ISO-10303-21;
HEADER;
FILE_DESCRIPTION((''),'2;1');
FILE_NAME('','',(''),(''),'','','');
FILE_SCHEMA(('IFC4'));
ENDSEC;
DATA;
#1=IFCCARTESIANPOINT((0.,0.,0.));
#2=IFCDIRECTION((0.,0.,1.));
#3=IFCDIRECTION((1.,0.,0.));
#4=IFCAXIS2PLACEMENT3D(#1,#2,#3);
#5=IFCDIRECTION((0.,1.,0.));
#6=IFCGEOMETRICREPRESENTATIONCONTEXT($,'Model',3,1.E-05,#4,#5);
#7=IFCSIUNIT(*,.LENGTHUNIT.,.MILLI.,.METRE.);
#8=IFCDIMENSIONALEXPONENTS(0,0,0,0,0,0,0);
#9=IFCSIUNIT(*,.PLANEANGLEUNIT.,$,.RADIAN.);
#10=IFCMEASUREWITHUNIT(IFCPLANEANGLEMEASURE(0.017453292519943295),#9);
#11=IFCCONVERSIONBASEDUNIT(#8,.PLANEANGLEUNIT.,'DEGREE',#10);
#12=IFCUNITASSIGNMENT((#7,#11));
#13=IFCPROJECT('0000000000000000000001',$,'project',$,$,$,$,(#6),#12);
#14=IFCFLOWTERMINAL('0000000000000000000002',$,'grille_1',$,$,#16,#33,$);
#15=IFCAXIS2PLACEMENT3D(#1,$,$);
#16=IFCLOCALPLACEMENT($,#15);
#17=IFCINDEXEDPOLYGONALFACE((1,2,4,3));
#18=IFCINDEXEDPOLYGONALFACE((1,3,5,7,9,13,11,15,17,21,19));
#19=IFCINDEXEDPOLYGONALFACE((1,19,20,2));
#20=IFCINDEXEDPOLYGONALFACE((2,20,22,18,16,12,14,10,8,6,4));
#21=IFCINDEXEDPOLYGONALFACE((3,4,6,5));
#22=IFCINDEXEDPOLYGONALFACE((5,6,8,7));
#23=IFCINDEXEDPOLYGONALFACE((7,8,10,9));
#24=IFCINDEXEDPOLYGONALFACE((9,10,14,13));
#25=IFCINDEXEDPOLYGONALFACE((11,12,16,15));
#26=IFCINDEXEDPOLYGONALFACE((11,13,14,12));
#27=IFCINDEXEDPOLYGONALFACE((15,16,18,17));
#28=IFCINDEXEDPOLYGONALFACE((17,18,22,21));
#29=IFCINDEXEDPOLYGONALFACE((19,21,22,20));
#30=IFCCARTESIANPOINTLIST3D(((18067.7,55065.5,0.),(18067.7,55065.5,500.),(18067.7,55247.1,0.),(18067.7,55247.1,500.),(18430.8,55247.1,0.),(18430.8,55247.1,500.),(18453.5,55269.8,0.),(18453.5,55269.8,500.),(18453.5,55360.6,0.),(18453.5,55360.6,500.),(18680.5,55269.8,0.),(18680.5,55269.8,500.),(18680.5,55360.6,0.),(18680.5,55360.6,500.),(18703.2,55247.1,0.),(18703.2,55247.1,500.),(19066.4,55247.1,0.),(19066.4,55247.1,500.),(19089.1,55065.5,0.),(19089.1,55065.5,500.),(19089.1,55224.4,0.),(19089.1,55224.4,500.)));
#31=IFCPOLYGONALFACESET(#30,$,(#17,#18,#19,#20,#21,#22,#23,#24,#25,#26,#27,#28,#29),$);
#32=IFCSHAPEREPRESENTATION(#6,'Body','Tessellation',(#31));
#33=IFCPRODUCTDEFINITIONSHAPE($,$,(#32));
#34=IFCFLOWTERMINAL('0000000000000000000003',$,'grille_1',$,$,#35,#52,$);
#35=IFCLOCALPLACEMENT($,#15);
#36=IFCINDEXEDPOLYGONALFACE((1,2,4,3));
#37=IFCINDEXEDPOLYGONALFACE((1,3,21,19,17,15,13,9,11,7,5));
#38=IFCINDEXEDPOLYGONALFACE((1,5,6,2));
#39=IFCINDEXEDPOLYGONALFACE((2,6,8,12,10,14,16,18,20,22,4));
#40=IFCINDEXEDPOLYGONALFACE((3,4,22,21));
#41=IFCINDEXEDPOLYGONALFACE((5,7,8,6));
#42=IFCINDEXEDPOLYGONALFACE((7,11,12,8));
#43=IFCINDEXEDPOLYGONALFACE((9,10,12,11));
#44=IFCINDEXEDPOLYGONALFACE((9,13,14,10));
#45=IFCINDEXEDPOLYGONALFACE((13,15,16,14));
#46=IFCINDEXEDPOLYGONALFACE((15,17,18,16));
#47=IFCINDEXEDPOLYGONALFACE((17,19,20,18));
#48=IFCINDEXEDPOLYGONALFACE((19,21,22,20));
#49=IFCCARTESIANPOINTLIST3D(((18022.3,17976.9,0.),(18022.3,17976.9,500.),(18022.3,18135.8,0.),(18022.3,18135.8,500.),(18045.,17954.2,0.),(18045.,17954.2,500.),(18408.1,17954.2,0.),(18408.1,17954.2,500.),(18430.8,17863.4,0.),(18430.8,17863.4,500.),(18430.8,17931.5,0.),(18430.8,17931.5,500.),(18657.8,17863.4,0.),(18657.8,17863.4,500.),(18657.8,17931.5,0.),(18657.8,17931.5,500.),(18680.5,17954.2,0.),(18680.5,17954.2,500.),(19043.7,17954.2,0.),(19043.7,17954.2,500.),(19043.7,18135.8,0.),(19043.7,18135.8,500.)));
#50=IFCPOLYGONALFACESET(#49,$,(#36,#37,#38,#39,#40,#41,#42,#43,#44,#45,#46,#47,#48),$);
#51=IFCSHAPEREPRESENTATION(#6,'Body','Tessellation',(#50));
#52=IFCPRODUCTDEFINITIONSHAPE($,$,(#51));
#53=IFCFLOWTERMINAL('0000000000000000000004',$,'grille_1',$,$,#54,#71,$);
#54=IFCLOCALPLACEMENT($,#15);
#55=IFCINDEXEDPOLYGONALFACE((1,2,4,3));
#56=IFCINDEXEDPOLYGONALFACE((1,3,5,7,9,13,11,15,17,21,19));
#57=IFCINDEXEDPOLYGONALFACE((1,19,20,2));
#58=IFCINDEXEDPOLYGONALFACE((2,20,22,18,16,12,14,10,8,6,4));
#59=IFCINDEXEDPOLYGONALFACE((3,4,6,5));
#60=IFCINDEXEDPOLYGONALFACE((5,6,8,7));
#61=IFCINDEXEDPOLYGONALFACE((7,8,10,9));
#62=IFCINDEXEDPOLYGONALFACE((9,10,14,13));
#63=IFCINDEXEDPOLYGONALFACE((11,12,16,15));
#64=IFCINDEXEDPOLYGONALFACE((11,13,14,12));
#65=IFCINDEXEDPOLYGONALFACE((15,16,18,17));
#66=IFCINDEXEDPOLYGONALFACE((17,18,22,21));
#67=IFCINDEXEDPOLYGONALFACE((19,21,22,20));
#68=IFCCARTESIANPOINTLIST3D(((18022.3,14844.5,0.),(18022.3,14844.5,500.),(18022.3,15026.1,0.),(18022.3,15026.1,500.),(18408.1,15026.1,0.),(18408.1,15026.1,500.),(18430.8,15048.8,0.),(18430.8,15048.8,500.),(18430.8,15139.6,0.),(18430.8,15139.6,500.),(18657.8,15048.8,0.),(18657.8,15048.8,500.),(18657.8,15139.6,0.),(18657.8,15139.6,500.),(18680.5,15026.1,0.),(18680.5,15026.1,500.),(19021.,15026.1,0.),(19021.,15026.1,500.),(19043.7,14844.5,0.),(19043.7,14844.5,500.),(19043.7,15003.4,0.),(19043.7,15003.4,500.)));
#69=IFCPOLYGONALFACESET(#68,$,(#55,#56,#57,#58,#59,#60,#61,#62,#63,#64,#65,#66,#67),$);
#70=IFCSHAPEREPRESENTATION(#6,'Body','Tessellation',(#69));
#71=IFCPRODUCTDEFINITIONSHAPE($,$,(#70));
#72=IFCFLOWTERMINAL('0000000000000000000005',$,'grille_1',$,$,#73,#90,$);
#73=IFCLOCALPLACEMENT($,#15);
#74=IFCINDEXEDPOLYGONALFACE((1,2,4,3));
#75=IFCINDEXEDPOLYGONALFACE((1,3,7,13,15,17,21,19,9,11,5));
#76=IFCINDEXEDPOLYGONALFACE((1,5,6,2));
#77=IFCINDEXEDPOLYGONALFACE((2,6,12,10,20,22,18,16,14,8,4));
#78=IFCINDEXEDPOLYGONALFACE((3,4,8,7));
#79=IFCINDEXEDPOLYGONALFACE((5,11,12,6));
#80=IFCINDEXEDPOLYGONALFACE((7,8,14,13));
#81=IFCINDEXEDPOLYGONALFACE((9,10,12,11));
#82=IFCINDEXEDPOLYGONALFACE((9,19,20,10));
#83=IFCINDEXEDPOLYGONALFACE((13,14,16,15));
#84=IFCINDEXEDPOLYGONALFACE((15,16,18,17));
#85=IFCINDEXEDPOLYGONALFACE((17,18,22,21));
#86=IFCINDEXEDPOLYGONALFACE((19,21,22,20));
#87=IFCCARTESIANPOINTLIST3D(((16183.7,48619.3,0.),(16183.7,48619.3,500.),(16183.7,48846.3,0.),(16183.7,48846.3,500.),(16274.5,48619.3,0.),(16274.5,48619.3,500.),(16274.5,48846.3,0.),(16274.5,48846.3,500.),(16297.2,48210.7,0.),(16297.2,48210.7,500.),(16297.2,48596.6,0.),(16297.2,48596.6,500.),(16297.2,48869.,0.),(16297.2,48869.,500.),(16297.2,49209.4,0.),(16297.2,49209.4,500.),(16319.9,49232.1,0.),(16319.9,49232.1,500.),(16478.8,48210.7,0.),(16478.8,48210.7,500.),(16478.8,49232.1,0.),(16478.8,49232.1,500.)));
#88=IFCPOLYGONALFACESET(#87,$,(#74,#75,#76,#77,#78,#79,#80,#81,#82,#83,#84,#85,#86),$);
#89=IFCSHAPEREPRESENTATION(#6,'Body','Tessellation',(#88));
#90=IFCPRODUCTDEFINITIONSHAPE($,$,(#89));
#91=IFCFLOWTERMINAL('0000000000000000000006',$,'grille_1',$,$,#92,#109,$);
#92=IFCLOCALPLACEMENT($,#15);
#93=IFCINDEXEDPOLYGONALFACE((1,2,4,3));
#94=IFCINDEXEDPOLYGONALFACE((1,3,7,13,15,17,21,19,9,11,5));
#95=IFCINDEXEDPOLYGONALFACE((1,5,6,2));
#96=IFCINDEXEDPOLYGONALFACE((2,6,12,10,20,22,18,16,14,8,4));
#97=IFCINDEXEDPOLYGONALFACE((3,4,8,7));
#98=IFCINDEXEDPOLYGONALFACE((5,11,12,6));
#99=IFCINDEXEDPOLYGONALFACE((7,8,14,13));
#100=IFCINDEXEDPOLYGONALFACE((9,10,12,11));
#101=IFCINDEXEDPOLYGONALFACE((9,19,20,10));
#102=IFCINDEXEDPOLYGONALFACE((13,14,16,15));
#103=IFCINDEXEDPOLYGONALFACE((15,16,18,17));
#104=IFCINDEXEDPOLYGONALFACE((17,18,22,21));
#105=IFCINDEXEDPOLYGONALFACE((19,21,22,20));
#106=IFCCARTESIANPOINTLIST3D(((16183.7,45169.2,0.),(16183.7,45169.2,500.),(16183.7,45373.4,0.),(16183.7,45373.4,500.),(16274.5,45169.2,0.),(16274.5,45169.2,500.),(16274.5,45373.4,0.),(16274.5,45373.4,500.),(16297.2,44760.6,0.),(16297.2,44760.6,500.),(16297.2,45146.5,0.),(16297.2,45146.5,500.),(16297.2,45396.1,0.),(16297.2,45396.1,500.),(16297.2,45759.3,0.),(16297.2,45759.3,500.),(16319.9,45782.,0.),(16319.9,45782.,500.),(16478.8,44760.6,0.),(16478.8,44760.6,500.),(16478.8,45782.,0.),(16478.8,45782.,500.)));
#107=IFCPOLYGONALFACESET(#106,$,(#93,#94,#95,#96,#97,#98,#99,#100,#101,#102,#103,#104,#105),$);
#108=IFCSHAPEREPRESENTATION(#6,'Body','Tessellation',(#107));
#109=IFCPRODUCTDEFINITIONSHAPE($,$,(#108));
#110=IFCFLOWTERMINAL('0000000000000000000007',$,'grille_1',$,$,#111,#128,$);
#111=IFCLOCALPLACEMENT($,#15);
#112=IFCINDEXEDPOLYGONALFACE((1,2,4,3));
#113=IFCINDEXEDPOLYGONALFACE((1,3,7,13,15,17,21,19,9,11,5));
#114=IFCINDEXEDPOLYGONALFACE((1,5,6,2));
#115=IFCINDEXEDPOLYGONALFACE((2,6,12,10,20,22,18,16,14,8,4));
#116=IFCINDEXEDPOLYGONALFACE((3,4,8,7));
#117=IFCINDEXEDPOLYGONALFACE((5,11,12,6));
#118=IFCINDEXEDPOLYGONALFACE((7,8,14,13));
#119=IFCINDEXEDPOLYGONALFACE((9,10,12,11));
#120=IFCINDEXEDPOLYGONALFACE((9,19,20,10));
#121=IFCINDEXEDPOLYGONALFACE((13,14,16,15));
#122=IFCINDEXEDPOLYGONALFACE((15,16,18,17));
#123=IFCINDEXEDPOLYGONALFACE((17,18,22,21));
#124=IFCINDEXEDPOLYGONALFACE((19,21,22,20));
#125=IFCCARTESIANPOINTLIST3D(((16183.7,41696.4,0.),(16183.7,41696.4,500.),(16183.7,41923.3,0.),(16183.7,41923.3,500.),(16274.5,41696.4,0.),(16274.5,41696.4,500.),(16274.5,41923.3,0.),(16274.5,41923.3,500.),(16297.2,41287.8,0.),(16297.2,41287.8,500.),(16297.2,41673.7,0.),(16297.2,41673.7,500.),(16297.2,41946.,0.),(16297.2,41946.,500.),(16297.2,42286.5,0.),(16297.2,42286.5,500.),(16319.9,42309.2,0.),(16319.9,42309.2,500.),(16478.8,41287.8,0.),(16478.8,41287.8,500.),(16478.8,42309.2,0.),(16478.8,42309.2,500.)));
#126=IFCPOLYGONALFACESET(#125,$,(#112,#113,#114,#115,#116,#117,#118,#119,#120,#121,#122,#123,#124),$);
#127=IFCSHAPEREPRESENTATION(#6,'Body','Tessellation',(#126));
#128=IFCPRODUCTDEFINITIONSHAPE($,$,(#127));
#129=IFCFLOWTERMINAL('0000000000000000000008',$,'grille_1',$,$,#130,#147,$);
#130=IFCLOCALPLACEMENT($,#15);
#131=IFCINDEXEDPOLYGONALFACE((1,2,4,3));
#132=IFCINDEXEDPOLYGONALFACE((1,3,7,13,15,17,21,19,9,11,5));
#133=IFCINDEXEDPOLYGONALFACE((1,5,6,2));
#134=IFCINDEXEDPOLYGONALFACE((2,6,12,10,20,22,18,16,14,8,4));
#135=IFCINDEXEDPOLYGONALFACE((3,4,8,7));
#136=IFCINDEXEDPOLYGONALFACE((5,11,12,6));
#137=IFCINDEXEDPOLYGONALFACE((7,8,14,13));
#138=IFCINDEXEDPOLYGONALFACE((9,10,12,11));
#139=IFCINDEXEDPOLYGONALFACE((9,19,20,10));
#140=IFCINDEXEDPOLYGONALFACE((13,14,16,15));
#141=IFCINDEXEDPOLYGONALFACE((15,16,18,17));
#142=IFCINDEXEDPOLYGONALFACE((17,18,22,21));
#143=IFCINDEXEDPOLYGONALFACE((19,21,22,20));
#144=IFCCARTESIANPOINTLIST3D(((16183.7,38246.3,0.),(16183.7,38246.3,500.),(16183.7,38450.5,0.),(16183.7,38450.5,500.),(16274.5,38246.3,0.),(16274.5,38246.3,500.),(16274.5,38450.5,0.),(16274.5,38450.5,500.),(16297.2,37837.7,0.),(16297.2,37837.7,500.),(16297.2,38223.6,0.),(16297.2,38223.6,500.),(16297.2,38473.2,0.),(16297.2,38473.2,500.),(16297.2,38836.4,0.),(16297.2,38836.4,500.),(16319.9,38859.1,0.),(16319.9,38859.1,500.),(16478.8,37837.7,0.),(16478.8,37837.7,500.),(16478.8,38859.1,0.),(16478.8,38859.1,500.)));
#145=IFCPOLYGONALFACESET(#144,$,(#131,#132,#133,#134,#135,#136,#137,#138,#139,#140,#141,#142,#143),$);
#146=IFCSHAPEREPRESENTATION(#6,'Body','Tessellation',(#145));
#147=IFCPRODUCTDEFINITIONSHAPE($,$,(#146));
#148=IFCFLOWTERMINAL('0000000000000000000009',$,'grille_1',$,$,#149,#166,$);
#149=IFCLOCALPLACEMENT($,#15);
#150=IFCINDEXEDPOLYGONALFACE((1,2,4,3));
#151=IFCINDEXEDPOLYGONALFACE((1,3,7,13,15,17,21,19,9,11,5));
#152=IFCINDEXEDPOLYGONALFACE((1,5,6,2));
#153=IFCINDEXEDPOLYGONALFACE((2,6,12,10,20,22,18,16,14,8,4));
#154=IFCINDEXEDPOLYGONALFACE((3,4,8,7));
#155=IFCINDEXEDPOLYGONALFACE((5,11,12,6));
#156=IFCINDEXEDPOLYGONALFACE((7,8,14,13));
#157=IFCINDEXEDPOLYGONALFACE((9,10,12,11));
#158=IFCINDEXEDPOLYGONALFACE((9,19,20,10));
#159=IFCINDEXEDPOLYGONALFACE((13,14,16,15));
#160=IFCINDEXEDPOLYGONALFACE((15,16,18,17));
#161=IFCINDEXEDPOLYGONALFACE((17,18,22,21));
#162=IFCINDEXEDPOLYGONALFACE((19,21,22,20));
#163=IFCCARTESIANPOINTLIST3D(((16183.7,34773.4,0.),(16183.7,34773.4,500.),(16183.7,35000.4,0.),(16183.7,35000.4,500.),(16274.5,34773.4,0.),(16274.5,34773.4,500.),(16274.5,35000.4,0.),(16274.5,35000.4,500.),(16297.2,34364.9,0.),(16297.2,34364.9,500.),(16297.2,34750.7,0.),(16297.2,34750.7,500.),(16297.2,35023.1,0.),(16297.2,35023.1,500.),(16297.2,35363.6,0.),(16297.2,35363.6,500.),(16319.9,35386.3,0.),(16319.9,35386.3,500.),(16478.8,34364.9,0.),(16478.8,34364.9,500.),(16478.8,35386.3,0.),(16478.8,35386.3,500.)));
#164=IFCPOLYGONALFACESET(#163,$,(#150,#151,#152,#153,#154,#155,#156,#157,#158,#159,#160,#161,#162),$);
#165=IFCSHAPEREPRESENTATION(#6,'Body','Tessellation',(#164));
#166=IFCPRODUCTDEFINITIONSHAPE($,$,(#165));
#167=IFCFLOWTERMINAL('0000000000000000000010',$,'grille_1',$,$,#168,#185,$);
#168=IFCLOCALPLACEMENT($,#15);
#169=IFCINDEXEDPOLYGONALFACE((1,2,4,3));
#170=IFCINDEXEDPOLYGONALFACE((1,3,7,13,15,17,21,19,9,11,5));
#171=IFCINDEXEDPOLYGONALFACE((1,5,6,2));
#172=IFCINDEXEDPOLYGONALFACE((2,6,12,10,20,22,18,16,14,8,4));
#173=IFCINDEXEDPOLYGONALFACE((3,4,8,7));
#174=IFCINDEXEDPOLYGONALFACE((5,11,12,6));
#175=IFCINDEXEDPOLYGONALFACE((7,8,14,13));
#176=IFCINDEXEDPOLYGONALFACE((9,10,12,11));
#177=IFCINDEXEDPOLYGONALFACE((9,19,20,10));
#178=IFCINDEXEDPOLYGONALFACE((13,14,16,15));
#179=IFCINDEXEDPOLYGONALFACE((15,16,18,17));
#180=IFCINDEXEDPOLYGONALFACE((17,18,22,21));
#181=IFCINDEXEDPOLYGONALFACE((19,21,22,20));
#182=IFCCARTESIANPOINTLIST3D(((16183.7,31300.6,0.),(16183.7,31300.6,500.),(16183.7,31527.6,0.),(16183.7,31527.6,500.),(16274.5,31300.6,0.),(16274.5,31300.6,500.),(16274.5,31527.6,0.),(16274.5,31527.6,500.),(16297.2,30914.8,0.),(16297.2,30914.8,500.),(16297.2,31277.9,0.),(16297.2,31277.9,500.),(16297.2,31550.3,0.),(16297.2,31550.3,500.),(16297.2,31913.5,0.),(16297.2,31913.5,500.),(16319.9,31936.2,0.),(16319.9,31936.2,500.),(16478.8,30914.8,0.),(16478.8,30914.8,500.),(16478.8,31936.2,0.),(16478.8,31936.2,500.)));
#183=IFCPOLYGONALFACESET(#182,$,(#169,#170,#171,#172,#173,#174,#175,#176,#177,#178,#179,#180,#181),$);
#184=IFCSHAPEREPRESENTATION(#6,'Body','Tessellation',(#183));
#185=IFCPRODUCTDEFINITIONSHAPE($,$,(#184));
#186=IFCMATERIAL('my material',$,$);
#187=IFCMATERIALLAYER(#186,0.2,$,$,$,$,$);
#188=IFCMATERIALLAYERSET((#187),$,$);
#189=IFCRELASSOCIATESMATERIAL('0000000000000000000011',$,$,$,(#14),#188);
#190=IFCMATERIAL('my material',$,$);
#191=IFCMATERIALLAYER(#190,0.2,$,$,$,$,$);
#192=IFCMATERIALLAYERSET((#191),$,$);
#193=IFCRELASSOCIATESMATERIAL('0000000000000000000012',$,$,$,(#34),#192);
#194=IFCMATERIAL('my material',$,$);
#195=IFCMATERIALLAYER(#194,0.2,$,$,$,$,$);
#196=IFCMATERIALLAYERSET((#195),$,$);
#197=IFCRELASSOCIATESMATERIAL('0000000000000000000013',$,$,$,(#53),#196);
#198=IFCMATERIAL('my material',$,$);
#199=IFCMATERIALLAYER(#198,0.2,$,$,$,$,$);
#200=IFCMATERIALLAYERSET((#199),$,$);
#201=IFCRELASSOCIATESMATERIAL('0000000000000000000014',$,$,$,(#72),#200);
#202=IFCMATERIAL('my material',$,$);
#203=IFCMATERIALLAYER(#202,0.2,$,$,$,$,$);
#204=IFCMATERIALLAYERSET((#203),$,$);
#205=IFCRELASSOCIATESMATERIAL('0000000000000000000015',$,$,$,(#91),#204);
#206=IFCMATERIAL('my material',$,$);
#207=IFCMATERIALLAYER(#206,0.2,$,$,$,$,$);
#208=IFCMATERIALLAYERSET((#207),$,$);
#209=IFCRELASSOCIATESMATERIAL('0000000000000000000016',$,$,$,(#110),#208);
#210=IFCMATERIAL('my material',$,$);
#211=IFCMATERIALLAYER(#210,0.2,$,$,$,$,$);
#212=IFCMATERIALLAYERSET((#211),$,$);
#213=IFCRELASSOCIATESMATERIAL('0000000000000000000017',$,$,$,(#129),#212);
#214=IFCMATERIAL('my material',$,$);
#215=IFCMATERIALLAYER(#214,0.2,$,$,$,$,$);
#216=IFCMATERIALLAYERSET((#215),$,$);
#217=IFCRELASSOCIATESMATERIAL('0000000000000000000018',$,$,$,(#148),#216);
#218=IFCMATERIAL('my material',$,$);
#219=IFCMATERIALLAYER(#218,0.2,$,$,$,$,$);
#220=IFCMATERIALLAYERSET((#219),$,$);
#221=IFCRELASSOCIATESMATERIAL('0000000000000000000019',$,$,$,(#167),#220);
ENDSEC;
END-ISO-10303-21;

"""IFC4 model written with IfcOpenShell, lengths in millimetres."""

from ifc_helpers import new_model, entity, si_unit, converted_unit, direction, origin_with_axes, place, context, project, polyline, outline, extrude, material, layer, layer_set, layer_usage, element, save


model = new_model("IFC4")

# Units and contexts
model_context = context("Model", 3, precision=1e-05, world=origin_with_axes(), true_north=direction((0.0, 1.0, 0.0)))
ifc_project = project(units=[si_unit("LENGTHUNIT", "METRE", prefix="MILLI"), converted_unit("PLANEANGLEUNIT", "DEGREE", entity("IfcPlaneAngleMeasure", 0.017453292519943295), si_unit("PLANEANGLEUNIT", "RADIAN"), dimensions=[0, 0, 0, 0, 0, 0, 0])], contexts=[model_context])

# Flow terminals
ifc_material_1 = material(Name="my material")
ifc_layer_1 = layer(ifc_material_1, 0.2)
ifc_layer_set_1 = layer_set([ifc_layer_1])
ifc_layer_usage_1 = layer_usage(ifc_layer_set_1, "AXIS2", "POSITIVE", -0.1)
flow_terminal_1_placement = place(None, origin_with_axes())
element("IfcFlowTerminal", 1, at=flow_terminal_1_placement, material=ifc_layer_usage_1, Name="grille_1", context=model_context, shape_type="SweptSolid", body=[
    extrude(outline(polyline([(18067.7, 55065.5), (19089.1, 55065.5), (19089.1, 55224.4), (19066.4, 55247.1), (18703.2, 55247.1), (18680.5, 55269.8), (18680.5, 55360.6), (18453.5, 55360.6), (18453.5, 55269.8), (18430.8, 55247.1), (18067.7, 55247.1), (18067.7, 55065.5)])), origin_with_axes(), (0.0, 0.0, 1.0), 500.0),
])
ifc_material_2 = material(Name="my material")
ifc_layer_2 = layer(ifc_material_2, 0.2)
ifc_layer_set_2 = layer_set([ifc_layer_2])
ifc_layer_usage_2 = layer_usage(ifc_layer_set_2, "AXIS2", "POSITIVE", -0.1)
flow_terminal_2_placement = place(None, origin_with_axes())
element("IfcFlowTerminal", 2, at=flow_terminal_2_placement, material=ifc_layer_usage_2, Name="grille_1", context=model_context, shape_type="SweptSolid", body=[
    extrude(outline(polyline([(18022.3, 17976.9), (18045.0, 17954.2), (18408.1, 17954.2), (18430.8, 17931.5), (18430.8, 17863.4), (18657.8, 17863.4), (18657.8, 17931.5), (18680.5, 17954.2), (19043.7, 17954.2), (19043.7, 18135.8), (18022.3, 18135.8), (18022.3, 17976.9)])), origin_with_axes(), (0.0, 0.0, 1.0), 500.0),
])
ifc_material_3 = material(Name="my material")
ifc_layer_3 = layer(ifc_material_3, 0.2)
ifc_layer_set_3 = layer_set([ifc_layer_3])
ifc_layer_usage_3 = layer_usage(ifc_layer_set_3, "AXIS2", "POSITIVE", -0.1)
flow_terminal_3_placement = place(None, origin_with_axes())
element("IfcFlowTerminal", 3, at=flow_terminal_3_placement, material=ifc_layer_usage_3, Name="grille_1", context=model_context, shape_type="SweptSolid", body=[
    extrude(outline(polyline([(18022.3, 14844.5), (19043.7, 14844.5), (19043.7, 15003.4), (19021.0, 15026.1), (18680.5, 15026.1), (18657.8, 15048.8), (18657.8, 15139.6), (18430.8, 15139.6), (18430.8, 15048.8), (18408.1, 15026.1), (18022.3, 15026.1), (18022.3, 14844.5)])), origin_with_axes(), (0.0, 0.0, 1.0), 500.0),
])
ifc_material_4 = material(Name="my material")
ifc_layer_4 = layer(ifc_material_4, 0.2)
ifc_layer_set_4 = layer_set([ifc_layer_4])
ifc_layer_usage_4 = layer_usage(ifc_layer_set_4, "AXIS2", "POSITIVE", -0.1)
flow_terminal_4_placement = place(None, origin_with_axes())
element("IfcFlowTerminal", 4, at=flow_terminal_4_placement, material=ifc_layer_usage_4, Name="grille_1", context=model_context, shape_type="SweptSolid", body=[
    extrude(outline(polyline([(16183.7, 48619.3), (16274.5, 48619.3), (16297.2, 48596.6), (16297.2, 48210.7), (16478.8, 48210.7), (16478.8, 49232.1), (16319.9, 49232.1), (16297.2, 49209.4), (16297.2, 48869.0), (16274.5, 48846.3), (16183.7, 48846.3), (16183.7, 48619.3)])), origin_with_axes(), (0.0, 0.0, 1.0), 500.0),
])
ifc_material_5 = material(Name="my material")
ifc_layer_5 = layer(ifc_material_5, 0.2)
ifc_layer_set_5 = layer_set([ifc_layer_5])
ifc_layer_usage_5 = layer_usage(ifc_layer_set_5, "AXIS2", "POSITIVE", -0.1)
flow_terminal_5_placement = place(None, origin_with_axes())
element("IfcFlowTerminal", 5, at=flow_terminal_5_placement, material=ifc_layer_usage_5, Name="grille_1", context=model_context, shape_type="SweptSolid", body=[
    extrude(outline(polyline([(16183.7, 45169.2), (16274.5, 45169.2), (16297.2, 45146.5), (16297.2, 44760.6), (16478.8, 44760.6), (16478.8, 45782.0), (16319.9, 45782.0), (16297.2, 45759.3), (16297.2, 45396.1), (16274.5, 45373.4), (16183.7, 45373.4), (16183.7, 45169.2)])), origin_with_axes(), (0.0, 0.0, 1.0), 500.0),
])
ifc_material_6 = material(Name="my material")
ifc_layer_6 = layer(ifc_material_6, 0.2)
ifc_layer_set_6 = layer_set([ifc_layer_6])
ifc_layer_usage_6 = layer_usage(ifc_layer_set_6, "AXIS2", "POSITIVE", -0.1)
flow_terminal_6_placement = place(None, origin_with_axes())
element("IfcFlowTerminal", 6, at=flow_terminal_6_placement, material=ifc_layer_usage_6, Name="grille_1", context=model_context, shape_type="SweptSolid", body=[
    extrude(outline(polyline([(16183.7, 41696.4), (16274.5, 41696.4), (16297.2, 41673.7), (16297.2, 41287.8), (16478.8, 41287.8), (16478.8, 42309.2), (16319.9, 42309.2), (16297.2, 42286.5), (16297.2, 41946.0), (16274.5, 41923.3), (16183.7, 41923.3), (16183.7, 41696.4)])), origin_with_axes(), (0.0, 0.0, 1.0), 500.0),
])
ifc_material_7 = material(Name="my material")
ifc_layer_7 = layer(ifc_material_7, 0.2)
ifc_layer_set_7 = layer_set([ifc_layer_7])
ifc_layer_usage_7 = layer_usage(ifc_layer_set_7, "AXIS2", "POSITIVE", -0.1)
flow_terminal_7_placement = place(None, origin_with_axes())
element("IfcFlowTerminal", 7, at=flow_terminal_7_placement, material=ifc_layer_usage_7, Name="grille_1", context=model_context, shape_type="SweptSolid", body=[
    extrude(outline(polyline([(16183.7, 38246.3), (16274.5, 38246.3), (16297.2, 38223.6), (16297.2, 37837.7), (16478.8, 37837.7), (16478.8, 38859.1), (16319.9, 38859.1), (16297.2, 38836.4), (16297.2, 38473.2), (16274.5, 38450.5), (16183.7, 38450.5), (16183.7, 38246.3)])), origin_with_axes(), (0.0, 0.0, 1.0), 500.0),
])
ifc_material_8 = material(Name="my material")
ifc_layer_8 = layer(ifc_material_8, 0.2)
ifc_layer_set_8 = layer_set([ifc_layer_8])
ifc_layer_usage_8 = layer_usage(ifc_layer_set_8, "AXIS2", "POSITIVE", -0.1)
flow_terminal_8_placement = place(None, origin_with_axes())
element("IfcFlowTerminal", 8, at=flow_terminal_8_placement, material=ifc_layer_usage_8, Name="grille_1", context=model_context, shape_type="SweptSolid", body=[
    extrude(outline(polyline([(16183.7, 34773.4), (16274.5, 34773.4), (16297.2, 34750.7), (16297.2, 34364.9), (16478.8, 34364.9), (16478.8, 35386.3), (16319.9, 35386.3), (16297.2, 35363.6), (16297.2, 35023.1), (16274.5, 35000.4), (16183.7, 35000.4), (16183.7, 34773.4)])), origin_with_axes(), (0.0, 0.0, 1.0), 500.0),
])
ifc_material_9 = material(Name="my material")
ifc_layer_9 = layer(ifc_material_9, 0.2)
ifc_layer_set_9 = layer_set([ifc_layer_9])
ifc_layer_usage_9 = layer_usage(ifc_layer_set_9, "AXIS2", "POSITIVE", -0.1)
flow_terminal_9_placement = place(None, origin_with_axes())
element("IfcFlowTerminal", 9, at=flow_terminal_9_placement, material=ifc_layer_usage_9, Name="grille_1", context=model_context, shape_type="SweptSolid", body=[
    extrude(outline(polyline([(16183.7, 31300.6), (16274.5, 31300.6), (16297.2, 31277.9), (16297.2, 30914.8), (16478.8, 30914.8), (16478.8, 31936.2), (16319.9, 31936.2), (16297.2, 31913.5), (16297.2, 31550.3), (16274.5, 31527.6), (16183.7, 31527.6), (16183.7, 31300.6)])), origin_with_axes(), (0.0, 0.0, 1.0), 500.0),
])

save(model, "model.ifc")
